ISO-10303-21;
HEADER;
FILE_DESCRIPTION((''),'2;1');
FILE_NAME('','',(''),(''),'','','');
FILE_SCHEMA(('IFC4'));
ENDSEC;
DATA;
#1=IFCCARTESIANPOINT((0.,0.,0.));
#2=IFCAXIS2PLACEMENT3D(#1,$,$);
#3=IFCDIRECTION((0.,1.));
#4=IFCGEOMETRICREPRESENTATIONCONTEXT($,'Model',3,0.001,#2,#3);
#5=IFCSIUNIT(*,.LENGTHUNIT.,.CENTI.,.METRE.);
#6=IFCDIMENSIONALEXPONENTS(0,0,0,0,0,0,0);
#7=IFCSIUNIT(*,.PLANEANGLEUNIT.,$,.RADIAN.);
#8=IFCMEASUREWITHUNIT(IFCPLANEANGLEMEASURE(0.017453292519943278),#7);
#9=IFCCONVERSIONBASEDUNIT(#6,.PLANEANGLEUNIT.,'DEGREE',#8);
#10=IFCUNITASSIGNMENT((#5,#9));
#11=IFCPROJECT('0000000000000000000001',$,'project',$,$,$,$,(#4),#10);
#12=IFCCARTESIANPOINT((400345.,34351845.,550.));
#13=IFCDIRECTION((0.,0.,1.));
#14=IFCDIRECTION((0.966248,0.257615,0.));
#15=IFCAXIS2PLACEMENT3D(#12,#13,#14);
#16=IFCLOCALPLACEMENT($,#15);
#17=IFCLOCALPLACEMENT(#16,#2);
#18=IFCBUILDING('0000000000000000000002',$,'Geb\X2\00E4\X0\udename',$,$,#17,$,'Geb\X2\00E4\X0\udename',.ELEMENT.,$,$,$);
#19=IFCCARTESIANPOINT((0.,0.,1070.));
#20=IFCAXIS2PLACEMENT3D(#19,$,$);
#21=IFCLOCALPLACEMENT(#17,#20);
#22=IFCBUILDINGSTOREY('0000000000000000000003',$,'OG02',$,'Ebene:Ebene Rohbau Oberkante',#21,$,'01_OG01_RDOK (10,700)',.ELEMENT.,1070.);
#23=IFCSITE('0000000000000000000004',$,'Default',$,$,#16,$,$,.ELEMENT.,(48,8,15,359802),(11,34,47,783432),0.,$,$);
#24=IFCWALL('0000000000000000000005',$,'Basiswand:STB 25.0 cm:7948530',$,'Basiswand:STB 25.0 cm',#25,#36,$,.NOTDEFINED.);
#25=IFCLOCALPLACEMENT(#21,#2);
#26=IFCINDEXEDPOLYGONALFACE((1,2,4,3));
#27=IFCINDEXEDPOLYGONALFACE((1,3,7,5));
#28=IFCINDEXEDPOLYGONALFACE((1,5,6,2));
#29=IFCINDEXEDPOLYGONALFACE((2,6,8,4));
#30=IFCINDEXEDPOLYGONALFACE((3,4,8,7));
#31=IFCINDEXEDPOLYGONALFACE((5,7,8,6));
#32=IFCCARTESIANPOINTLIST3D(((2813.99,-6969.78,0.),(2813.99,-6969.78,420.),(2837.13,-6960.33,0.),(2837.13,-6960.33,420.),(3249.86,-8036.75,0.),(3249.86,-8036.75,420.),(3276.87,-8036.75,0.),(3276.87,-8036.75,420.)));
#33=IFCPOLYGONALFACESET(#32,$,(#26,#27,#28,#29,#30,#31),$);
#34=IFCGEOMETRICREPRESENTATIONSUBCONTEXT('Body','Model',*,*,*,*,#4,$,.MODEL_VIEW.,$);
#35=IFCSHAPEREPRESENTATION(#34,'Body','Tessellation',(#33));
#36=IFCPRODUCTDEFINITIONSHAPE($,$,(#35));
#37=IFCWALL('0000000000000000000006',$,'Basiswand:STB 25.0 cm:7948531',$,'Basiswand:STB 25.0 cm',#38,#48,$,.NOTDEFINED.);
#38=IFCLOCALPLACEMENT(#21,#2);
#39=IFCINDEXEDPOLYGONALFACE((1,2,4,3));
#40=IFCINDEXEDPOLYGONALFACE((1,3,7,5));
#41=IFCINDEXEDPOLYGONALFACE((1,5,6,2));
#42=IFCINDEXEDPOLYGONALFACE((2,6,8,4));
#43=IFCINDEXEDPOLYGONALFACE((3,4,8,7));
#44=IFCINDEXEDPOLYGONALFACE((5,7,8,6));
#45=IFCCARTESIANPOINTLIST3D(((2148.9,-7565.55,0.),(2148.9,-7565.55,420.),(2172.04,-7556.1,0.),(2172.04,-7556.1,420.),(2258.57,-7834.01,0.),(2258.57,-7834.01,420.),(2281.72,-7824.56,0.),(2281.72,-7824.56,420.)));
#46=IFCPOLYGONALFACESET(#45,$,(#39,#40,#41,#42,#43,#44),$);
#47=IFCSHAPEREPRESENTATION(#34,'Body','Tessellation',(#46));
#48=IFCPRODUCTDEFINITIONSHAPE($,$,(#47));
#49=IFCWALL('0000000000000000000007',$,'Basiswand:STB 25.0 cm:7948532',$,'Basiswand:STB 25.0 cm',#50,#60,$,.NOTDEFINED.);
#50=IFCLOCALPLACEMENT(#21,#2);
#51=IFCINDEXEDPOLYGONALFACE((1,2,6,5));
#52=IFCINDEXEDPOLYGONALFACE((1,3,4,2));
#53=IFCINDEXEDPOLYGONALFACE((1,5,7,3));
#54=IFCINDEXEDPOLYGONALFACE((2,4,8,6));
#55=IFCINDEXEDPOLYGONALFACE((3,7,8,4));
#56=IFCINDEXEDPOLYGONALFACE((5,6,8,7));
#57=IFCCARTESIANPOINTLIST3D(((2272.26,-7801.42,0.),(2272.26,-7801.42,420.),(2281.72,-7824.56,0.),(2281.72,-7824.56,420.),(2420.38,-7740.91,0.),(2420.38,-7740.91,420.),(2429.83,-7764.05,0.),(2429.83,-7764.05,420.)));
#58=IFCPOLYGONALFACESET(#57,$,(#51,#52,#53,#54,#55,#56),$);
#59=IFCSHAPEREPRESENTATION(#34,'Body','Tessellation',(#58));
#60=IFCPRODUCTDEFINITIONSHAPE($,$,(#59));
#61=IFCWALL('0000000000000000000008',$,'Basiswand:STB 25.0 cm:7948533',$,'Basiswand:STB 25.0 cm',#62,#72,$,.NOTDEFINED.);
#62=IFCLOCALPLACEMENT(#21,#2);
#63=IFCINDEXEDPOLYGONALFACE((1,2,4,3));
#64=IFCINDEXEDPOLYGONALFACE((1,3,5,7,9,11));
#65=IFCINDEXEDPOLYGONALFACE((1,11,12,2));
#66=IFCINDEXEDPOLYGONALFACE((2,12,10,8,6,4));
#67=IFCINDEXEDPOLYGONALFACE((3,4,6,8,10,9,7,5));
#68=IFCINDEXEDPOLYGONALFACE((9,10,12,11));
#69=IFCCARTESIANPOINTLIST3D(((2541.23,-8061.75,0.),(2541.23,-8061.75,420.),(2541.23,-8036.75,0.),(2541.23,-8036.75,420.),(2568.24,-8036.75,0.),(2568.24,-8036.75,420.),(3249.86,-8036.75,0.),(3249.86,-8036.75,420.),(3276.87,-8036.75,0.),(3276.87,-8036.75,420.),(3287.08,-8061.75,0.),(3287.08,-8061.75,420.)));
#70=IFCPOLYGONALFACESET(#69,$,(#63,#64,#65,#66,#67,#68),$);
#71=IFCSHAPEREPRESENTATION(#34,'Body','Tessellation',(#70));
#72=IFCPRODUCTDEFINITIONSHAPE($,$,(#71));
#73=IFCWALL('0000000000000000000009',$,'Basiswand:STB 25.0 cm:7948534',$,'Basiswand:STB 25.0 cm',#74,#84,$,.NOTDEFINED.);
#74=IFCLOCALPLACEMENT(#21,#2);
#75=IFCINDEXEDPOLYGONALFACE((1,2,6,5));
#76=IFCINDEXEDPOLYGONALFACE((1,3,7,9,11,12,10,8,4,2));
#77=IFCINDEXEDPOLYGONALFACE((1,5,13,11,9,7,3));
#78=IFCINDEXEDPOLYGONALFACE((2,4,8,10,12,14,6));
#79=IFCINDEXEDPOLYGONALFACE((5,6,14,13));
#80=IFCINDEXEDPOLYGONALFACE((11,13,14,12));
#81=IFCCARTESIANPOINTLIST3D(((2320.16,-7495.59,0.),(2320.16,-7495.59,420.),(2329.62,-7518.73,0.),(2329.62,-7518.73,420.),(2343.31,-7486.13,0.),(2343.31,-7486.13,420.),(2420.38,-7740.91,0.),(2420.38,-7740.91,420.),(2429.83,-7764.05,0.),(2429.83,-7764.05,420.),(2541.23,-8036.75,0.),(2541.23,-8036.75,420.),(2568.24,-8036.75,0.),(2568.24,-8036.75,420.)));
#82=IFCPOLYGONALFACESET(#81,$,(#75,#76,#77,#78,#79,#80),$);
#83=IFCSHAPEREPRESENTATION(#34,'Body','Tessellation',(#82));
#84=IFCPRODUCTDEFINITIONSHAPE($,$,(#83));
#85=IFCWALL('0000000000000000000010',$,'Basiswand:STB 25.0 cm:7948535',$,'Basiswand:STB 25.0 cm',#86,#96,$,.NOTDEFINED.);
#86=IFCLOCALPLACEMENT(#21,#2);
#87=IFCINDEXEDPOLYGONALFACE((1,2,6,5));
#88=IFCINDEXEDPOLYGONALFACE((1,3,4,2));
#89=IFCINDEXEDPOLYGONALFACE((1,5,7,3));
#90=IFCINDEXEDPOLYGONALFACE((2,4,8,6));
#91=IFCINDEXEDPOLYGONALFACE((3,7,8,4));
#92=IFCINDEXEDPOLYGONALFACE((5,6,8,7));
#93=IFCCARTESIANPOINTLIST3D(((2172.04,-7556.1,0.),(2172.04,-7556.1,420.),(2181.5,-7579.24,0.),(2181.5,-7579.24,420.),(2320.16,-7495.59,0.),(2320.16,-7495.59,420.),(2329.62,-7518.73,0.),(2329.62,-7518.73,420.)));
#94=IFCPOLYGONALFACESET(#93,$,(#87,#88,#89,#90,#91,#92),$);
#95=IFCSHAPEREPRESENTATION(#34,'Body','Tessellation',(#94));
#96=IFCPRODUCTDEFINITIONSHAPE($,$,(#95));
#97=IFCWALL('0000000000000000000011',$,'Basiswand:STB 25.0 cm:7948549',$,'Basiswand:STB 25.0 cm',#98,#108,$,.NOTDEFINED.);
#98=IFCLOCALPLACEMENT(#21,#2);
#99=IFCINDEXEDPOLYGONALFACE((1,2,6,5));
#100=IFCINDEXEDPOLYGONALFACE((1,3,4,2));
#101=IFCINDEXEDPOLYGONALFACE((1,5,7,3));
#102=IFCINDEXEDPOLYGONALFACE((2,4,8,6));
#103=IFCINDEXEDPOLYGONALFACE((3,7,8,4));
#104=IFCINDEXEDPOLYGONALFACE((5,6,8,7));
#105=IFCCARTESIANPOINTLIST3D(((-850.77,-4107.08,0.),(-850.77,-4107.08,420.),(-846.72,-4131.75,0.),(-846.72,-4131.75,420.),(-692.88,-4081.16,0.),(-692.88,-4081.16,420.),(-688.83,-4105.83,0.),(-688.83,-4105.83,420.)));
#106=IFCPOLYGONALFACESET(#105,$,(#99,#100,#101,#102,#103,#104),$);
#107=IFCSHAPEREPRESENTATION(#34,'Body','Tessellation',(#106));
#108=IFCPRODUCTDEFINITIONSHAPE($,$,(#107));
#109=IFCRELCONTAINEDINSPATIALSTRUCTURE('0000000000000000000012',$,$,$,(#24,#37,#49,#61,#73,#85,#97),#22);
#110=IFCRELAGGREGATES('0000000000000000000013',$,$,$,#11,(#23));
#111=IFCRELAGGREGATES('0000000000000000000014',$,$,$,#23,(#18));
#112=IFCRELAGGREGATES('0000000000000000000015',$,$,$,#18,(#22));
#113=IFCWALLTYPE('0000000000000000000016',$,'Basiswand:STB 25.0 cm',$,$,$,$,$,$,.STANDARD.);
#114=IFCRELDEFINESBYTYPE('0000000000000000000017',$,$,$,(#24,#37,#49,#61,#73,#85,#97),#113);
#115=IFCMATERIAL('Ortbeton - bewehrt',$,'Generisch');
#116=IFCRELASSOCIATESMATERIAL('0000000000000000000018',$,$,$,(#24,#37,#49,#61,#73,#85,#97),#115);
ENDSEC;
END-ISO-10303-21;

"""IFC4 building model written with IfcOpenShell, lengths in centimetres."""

from ifc_helpers import new_model, entity, si_unit, converted_unit, direction, frame, origin, place, context, subcontext, project, spatial, indexed_curve, outline, extrude, material, type_object, element, save


model = new_model("IFC4")

# Units and contexts
model_context = context("Model", 3, precision=0.001, world=origin(), true_north=direction((0.0, 1.0)))
body_context = subcontext(model_context, "Body", "Model", "MODEL_VIEW")
ifc_project = project(units=[si_unit("LENGTHUNIT", "METRE", prefix="CENTI"), converted_unit("PLANEANGLEUNIT", "DEGREE", entity("IfcPlaneAngleMeasure", 0.017453292519943278), si_unit("PLANEANGLEUNIT", "RADIAN"), dimensions=[0, 0, 0, 0, 0, 0, 0])], contexts=[model_context])

# Site, building, storey
site_placement = place(None, frame((400345.0, 34351845.0, 550.0), z_axis=(0.0, 0.0, 1.0), x_axis=(0.966248, 0.257615, 0.0)))
site = spatial("IfcSite", under=ifc_project, at=site_placement, Name="Default", CompositionType="ELEMENT", RefLatitude=(48, 8, 15, 359802), RefLongitude=(11, 34, 47, 783432), RefElevation=0.0)
building_placement = place(site_placement, origin())
building = spatial("IfcBuilding", under=site, at=building_placement, Name="Gebäudename", LongName="Gebäudename", CompositionType="ELEMENT")
storey_placement = place(building_placement, frame((0.0, 0.0, 1070.0)))
storey = spatial("IfcBuildingStorey", under=building, at=storey_placement, Name="OG02", ObjectType="Ebene:Ebene Rohbau Oberkante", LongName="01_OG01_RDOK (10,700)", CompositionType="ELEMENT", Elevation=1070.0)

# Shared definitions
ifc_material = material(Name="Ortbeton - bewehrt", Category="Generisch")

# Walls
wall_type = type_object("IfcWallType", Name="Basiswand:STB 25.0 cm", PredefinedType="STANDARD")
wall_1_placement = place(storey_placement, frame((2825.56, -6965.06, 0.0), z_axis=(0.0, 0.0, 1.0), x_axis=(0.378175, -0.925734, 0.0)))
element("IfcWall", 1, at=wall_1_placement, inside=storey, type_object=wall_type, material=ifc_material, Name="Basiswand:STB 25.0 cm:7948530", ObjectType="Basiswand:STB 25.0 cm", PredefinedType="NOTDEFINED", context=body_context, shape_type="SweptSolid", body=[
    extrude(outline(indexed_curve([(1152.56, -12.5), (1162.77, 12.5), (0.0, 12.5), (0.0, -12.5), (1152.56, -12.5)], self_intersect=False)), origin(), (0.0, 0.0, 1.0), 420.0),
])
wall_2_placement = place(storey_placement, frame((2160.47, -7560.82, 0.0), z_axis=(0.0, 0.0, 1.0), x_axis=(0.378175, -0.925734, 0.0)))
element("IfcWall", 2, at=wall_2_placement, inside=storey, type_object=wall_type, material=ifc_material, Name="Basiswand:STB 25.0 cm:7948531", ObjectType="Basiswand:STB 25.0 cm", PredefinedType="NOTDEFINED", context=body_context, shape_type="SweptSolid", body=[
    extrude(outline(indexed_curve([(290.0, 12.5), (0.0, 12.5), (0.0, -12.5), (290.0, -12.5), (290.0, 12.5)], self_intersect=False)), origin(), (0.0, 0.0, 1.0), 420.0),
])
wall_3_placement = place(storey_placement, frame((2276.99, -7812.99, 0.0), z_axis=(0.0, 0.0, 1.0), x_axis=(0.925734, 0.378175, 0.0)))
element("IfcWall", 3, at=wall_3_placement, inside=storey, type_object=wall_type, material=ifc_material, Name="Basiswand:STB 25.0 cm:7948532", ObjectType="Basiswand:STB 25.0 cm", PredefinedType="NOTDEFINED", context=body_context, shape_type="SweptSolid", body=[
    extrude(outline(indexed_curve([(160.0, 12.5), (0.0, 12.5), (0.0, -12.5), (160.0, -12.5), (160.0, 12.5)], self_intersect=False)), origin(), (0.0, 0.0, 1.0), 420.0),
])
wall_4_placement = place(storey_placement, frame((3287.08, -8049.25, 0.0), z_axis=(0.0, 0.0, 1.0), x_axis=(-1.0, 0.0, 0.0)))
element("IfcWall", 4, at=wall_4_placement, inside=storey, type_object=wall_type, material=ifc_material, Name="Basiswand:STB 25.0 cm:7948533", ObjectType="Basiswand:STB 25.0 cm", PredefinedType="NOTDEFINED", context=body_context, shape_type="SweptSolid", body=[
    extrude(outline(indexed_curve([(745.85, -12.5), (745.85, 12.5), (0.0, 12.5), (10.21, -12.5), (37.22, -12.5), (718.84, -12.5), (745.85, -12.5)], self_intersect=False)), origin(), (0.0, 0.0, 1.0), 420.0),
])
wall_5_placement = place(storey_placement, frame((2331.73, -7490.86, 0.0), z_axis=(0.0, 0.0, 1.0), x_axis=(0.378175, -0.925734, 0.0)))
element("IfcWall", 5, at=wall_5_placement, inside=storey, type_object=wall_type, material=ifc_material, Name="Basiswand:STB 25.0 cm:7948534", ObjectType="Basiswand:STB 25.0 cm", PredefinedType="NOTDEFINED", context=body_context, shape_type="SweptSolid", body=[
    extrude(outline(indexed_curve([(584.57, -12.5), (594.78, 12.5), (0.0, 12.5), (0.0, -12.5), (25.0, -12.5), (265.0, -12.5), (290.0, -12.5), (584.57, -12.5)], self_intersect=False)), origin(), (0.0, 0.0, 1.0), 420.0),
])
wall_6_placement = place(storey_placement, frame((2176.77, -7567.67, 0.0), z_axis=(0.0, 0.0, 1.0), x_axis=(0.925734, 0.378175, 0.0)))
element("IfcWall", 6, at=wall_6_placement, inside=storey, type_object=wall_type, material=ifc_material, Name="Basiswand:STB 25.0 cm:7948535", ObjectType="Basiswand:STB 25.0 cm", PredefinedType="NOTDEFINED", context=body_context, shape_type="SweptSolid", body=[
    extrude(outline(indexed_curve([(160.0, 12.5), (0.0, 12.5), (0.0, -12.5), (160.0, -12.5), (160.0, 12.5)], self_intersect=False)), origin(), (0.0, 0.0, 1.0), 420.0),
])
wall_7_placement = place(storey_placement, frame((-848.74, -4119.42, 0.0), z_axis=(0.0, 0.0, 1.0), x_axis=(0.986789, 0.162011, 0.0)))
element("IfcWall", 7, at=wall_7_placement, inside=storey, type_object=wall_type, material=ifc_material, Name="Basiswand:STB 25.0 cm:7948549", ObjectType="Basiswand:STB 25.0 cm", PredefinedType="NOTDEFINED", context=body_context, shape_type="SweptSolid", body=[
    extrude(outline(indexed_curve([(160.0, 12.5), (0.0, 12.5), (0.0, -12.5), (160.0, -12.5), (160.0, 12.5)], self_intersect=False)), origin(), (0.0, 0.0, 1.0), 420.0),
])

save(model, "model.ifc")
